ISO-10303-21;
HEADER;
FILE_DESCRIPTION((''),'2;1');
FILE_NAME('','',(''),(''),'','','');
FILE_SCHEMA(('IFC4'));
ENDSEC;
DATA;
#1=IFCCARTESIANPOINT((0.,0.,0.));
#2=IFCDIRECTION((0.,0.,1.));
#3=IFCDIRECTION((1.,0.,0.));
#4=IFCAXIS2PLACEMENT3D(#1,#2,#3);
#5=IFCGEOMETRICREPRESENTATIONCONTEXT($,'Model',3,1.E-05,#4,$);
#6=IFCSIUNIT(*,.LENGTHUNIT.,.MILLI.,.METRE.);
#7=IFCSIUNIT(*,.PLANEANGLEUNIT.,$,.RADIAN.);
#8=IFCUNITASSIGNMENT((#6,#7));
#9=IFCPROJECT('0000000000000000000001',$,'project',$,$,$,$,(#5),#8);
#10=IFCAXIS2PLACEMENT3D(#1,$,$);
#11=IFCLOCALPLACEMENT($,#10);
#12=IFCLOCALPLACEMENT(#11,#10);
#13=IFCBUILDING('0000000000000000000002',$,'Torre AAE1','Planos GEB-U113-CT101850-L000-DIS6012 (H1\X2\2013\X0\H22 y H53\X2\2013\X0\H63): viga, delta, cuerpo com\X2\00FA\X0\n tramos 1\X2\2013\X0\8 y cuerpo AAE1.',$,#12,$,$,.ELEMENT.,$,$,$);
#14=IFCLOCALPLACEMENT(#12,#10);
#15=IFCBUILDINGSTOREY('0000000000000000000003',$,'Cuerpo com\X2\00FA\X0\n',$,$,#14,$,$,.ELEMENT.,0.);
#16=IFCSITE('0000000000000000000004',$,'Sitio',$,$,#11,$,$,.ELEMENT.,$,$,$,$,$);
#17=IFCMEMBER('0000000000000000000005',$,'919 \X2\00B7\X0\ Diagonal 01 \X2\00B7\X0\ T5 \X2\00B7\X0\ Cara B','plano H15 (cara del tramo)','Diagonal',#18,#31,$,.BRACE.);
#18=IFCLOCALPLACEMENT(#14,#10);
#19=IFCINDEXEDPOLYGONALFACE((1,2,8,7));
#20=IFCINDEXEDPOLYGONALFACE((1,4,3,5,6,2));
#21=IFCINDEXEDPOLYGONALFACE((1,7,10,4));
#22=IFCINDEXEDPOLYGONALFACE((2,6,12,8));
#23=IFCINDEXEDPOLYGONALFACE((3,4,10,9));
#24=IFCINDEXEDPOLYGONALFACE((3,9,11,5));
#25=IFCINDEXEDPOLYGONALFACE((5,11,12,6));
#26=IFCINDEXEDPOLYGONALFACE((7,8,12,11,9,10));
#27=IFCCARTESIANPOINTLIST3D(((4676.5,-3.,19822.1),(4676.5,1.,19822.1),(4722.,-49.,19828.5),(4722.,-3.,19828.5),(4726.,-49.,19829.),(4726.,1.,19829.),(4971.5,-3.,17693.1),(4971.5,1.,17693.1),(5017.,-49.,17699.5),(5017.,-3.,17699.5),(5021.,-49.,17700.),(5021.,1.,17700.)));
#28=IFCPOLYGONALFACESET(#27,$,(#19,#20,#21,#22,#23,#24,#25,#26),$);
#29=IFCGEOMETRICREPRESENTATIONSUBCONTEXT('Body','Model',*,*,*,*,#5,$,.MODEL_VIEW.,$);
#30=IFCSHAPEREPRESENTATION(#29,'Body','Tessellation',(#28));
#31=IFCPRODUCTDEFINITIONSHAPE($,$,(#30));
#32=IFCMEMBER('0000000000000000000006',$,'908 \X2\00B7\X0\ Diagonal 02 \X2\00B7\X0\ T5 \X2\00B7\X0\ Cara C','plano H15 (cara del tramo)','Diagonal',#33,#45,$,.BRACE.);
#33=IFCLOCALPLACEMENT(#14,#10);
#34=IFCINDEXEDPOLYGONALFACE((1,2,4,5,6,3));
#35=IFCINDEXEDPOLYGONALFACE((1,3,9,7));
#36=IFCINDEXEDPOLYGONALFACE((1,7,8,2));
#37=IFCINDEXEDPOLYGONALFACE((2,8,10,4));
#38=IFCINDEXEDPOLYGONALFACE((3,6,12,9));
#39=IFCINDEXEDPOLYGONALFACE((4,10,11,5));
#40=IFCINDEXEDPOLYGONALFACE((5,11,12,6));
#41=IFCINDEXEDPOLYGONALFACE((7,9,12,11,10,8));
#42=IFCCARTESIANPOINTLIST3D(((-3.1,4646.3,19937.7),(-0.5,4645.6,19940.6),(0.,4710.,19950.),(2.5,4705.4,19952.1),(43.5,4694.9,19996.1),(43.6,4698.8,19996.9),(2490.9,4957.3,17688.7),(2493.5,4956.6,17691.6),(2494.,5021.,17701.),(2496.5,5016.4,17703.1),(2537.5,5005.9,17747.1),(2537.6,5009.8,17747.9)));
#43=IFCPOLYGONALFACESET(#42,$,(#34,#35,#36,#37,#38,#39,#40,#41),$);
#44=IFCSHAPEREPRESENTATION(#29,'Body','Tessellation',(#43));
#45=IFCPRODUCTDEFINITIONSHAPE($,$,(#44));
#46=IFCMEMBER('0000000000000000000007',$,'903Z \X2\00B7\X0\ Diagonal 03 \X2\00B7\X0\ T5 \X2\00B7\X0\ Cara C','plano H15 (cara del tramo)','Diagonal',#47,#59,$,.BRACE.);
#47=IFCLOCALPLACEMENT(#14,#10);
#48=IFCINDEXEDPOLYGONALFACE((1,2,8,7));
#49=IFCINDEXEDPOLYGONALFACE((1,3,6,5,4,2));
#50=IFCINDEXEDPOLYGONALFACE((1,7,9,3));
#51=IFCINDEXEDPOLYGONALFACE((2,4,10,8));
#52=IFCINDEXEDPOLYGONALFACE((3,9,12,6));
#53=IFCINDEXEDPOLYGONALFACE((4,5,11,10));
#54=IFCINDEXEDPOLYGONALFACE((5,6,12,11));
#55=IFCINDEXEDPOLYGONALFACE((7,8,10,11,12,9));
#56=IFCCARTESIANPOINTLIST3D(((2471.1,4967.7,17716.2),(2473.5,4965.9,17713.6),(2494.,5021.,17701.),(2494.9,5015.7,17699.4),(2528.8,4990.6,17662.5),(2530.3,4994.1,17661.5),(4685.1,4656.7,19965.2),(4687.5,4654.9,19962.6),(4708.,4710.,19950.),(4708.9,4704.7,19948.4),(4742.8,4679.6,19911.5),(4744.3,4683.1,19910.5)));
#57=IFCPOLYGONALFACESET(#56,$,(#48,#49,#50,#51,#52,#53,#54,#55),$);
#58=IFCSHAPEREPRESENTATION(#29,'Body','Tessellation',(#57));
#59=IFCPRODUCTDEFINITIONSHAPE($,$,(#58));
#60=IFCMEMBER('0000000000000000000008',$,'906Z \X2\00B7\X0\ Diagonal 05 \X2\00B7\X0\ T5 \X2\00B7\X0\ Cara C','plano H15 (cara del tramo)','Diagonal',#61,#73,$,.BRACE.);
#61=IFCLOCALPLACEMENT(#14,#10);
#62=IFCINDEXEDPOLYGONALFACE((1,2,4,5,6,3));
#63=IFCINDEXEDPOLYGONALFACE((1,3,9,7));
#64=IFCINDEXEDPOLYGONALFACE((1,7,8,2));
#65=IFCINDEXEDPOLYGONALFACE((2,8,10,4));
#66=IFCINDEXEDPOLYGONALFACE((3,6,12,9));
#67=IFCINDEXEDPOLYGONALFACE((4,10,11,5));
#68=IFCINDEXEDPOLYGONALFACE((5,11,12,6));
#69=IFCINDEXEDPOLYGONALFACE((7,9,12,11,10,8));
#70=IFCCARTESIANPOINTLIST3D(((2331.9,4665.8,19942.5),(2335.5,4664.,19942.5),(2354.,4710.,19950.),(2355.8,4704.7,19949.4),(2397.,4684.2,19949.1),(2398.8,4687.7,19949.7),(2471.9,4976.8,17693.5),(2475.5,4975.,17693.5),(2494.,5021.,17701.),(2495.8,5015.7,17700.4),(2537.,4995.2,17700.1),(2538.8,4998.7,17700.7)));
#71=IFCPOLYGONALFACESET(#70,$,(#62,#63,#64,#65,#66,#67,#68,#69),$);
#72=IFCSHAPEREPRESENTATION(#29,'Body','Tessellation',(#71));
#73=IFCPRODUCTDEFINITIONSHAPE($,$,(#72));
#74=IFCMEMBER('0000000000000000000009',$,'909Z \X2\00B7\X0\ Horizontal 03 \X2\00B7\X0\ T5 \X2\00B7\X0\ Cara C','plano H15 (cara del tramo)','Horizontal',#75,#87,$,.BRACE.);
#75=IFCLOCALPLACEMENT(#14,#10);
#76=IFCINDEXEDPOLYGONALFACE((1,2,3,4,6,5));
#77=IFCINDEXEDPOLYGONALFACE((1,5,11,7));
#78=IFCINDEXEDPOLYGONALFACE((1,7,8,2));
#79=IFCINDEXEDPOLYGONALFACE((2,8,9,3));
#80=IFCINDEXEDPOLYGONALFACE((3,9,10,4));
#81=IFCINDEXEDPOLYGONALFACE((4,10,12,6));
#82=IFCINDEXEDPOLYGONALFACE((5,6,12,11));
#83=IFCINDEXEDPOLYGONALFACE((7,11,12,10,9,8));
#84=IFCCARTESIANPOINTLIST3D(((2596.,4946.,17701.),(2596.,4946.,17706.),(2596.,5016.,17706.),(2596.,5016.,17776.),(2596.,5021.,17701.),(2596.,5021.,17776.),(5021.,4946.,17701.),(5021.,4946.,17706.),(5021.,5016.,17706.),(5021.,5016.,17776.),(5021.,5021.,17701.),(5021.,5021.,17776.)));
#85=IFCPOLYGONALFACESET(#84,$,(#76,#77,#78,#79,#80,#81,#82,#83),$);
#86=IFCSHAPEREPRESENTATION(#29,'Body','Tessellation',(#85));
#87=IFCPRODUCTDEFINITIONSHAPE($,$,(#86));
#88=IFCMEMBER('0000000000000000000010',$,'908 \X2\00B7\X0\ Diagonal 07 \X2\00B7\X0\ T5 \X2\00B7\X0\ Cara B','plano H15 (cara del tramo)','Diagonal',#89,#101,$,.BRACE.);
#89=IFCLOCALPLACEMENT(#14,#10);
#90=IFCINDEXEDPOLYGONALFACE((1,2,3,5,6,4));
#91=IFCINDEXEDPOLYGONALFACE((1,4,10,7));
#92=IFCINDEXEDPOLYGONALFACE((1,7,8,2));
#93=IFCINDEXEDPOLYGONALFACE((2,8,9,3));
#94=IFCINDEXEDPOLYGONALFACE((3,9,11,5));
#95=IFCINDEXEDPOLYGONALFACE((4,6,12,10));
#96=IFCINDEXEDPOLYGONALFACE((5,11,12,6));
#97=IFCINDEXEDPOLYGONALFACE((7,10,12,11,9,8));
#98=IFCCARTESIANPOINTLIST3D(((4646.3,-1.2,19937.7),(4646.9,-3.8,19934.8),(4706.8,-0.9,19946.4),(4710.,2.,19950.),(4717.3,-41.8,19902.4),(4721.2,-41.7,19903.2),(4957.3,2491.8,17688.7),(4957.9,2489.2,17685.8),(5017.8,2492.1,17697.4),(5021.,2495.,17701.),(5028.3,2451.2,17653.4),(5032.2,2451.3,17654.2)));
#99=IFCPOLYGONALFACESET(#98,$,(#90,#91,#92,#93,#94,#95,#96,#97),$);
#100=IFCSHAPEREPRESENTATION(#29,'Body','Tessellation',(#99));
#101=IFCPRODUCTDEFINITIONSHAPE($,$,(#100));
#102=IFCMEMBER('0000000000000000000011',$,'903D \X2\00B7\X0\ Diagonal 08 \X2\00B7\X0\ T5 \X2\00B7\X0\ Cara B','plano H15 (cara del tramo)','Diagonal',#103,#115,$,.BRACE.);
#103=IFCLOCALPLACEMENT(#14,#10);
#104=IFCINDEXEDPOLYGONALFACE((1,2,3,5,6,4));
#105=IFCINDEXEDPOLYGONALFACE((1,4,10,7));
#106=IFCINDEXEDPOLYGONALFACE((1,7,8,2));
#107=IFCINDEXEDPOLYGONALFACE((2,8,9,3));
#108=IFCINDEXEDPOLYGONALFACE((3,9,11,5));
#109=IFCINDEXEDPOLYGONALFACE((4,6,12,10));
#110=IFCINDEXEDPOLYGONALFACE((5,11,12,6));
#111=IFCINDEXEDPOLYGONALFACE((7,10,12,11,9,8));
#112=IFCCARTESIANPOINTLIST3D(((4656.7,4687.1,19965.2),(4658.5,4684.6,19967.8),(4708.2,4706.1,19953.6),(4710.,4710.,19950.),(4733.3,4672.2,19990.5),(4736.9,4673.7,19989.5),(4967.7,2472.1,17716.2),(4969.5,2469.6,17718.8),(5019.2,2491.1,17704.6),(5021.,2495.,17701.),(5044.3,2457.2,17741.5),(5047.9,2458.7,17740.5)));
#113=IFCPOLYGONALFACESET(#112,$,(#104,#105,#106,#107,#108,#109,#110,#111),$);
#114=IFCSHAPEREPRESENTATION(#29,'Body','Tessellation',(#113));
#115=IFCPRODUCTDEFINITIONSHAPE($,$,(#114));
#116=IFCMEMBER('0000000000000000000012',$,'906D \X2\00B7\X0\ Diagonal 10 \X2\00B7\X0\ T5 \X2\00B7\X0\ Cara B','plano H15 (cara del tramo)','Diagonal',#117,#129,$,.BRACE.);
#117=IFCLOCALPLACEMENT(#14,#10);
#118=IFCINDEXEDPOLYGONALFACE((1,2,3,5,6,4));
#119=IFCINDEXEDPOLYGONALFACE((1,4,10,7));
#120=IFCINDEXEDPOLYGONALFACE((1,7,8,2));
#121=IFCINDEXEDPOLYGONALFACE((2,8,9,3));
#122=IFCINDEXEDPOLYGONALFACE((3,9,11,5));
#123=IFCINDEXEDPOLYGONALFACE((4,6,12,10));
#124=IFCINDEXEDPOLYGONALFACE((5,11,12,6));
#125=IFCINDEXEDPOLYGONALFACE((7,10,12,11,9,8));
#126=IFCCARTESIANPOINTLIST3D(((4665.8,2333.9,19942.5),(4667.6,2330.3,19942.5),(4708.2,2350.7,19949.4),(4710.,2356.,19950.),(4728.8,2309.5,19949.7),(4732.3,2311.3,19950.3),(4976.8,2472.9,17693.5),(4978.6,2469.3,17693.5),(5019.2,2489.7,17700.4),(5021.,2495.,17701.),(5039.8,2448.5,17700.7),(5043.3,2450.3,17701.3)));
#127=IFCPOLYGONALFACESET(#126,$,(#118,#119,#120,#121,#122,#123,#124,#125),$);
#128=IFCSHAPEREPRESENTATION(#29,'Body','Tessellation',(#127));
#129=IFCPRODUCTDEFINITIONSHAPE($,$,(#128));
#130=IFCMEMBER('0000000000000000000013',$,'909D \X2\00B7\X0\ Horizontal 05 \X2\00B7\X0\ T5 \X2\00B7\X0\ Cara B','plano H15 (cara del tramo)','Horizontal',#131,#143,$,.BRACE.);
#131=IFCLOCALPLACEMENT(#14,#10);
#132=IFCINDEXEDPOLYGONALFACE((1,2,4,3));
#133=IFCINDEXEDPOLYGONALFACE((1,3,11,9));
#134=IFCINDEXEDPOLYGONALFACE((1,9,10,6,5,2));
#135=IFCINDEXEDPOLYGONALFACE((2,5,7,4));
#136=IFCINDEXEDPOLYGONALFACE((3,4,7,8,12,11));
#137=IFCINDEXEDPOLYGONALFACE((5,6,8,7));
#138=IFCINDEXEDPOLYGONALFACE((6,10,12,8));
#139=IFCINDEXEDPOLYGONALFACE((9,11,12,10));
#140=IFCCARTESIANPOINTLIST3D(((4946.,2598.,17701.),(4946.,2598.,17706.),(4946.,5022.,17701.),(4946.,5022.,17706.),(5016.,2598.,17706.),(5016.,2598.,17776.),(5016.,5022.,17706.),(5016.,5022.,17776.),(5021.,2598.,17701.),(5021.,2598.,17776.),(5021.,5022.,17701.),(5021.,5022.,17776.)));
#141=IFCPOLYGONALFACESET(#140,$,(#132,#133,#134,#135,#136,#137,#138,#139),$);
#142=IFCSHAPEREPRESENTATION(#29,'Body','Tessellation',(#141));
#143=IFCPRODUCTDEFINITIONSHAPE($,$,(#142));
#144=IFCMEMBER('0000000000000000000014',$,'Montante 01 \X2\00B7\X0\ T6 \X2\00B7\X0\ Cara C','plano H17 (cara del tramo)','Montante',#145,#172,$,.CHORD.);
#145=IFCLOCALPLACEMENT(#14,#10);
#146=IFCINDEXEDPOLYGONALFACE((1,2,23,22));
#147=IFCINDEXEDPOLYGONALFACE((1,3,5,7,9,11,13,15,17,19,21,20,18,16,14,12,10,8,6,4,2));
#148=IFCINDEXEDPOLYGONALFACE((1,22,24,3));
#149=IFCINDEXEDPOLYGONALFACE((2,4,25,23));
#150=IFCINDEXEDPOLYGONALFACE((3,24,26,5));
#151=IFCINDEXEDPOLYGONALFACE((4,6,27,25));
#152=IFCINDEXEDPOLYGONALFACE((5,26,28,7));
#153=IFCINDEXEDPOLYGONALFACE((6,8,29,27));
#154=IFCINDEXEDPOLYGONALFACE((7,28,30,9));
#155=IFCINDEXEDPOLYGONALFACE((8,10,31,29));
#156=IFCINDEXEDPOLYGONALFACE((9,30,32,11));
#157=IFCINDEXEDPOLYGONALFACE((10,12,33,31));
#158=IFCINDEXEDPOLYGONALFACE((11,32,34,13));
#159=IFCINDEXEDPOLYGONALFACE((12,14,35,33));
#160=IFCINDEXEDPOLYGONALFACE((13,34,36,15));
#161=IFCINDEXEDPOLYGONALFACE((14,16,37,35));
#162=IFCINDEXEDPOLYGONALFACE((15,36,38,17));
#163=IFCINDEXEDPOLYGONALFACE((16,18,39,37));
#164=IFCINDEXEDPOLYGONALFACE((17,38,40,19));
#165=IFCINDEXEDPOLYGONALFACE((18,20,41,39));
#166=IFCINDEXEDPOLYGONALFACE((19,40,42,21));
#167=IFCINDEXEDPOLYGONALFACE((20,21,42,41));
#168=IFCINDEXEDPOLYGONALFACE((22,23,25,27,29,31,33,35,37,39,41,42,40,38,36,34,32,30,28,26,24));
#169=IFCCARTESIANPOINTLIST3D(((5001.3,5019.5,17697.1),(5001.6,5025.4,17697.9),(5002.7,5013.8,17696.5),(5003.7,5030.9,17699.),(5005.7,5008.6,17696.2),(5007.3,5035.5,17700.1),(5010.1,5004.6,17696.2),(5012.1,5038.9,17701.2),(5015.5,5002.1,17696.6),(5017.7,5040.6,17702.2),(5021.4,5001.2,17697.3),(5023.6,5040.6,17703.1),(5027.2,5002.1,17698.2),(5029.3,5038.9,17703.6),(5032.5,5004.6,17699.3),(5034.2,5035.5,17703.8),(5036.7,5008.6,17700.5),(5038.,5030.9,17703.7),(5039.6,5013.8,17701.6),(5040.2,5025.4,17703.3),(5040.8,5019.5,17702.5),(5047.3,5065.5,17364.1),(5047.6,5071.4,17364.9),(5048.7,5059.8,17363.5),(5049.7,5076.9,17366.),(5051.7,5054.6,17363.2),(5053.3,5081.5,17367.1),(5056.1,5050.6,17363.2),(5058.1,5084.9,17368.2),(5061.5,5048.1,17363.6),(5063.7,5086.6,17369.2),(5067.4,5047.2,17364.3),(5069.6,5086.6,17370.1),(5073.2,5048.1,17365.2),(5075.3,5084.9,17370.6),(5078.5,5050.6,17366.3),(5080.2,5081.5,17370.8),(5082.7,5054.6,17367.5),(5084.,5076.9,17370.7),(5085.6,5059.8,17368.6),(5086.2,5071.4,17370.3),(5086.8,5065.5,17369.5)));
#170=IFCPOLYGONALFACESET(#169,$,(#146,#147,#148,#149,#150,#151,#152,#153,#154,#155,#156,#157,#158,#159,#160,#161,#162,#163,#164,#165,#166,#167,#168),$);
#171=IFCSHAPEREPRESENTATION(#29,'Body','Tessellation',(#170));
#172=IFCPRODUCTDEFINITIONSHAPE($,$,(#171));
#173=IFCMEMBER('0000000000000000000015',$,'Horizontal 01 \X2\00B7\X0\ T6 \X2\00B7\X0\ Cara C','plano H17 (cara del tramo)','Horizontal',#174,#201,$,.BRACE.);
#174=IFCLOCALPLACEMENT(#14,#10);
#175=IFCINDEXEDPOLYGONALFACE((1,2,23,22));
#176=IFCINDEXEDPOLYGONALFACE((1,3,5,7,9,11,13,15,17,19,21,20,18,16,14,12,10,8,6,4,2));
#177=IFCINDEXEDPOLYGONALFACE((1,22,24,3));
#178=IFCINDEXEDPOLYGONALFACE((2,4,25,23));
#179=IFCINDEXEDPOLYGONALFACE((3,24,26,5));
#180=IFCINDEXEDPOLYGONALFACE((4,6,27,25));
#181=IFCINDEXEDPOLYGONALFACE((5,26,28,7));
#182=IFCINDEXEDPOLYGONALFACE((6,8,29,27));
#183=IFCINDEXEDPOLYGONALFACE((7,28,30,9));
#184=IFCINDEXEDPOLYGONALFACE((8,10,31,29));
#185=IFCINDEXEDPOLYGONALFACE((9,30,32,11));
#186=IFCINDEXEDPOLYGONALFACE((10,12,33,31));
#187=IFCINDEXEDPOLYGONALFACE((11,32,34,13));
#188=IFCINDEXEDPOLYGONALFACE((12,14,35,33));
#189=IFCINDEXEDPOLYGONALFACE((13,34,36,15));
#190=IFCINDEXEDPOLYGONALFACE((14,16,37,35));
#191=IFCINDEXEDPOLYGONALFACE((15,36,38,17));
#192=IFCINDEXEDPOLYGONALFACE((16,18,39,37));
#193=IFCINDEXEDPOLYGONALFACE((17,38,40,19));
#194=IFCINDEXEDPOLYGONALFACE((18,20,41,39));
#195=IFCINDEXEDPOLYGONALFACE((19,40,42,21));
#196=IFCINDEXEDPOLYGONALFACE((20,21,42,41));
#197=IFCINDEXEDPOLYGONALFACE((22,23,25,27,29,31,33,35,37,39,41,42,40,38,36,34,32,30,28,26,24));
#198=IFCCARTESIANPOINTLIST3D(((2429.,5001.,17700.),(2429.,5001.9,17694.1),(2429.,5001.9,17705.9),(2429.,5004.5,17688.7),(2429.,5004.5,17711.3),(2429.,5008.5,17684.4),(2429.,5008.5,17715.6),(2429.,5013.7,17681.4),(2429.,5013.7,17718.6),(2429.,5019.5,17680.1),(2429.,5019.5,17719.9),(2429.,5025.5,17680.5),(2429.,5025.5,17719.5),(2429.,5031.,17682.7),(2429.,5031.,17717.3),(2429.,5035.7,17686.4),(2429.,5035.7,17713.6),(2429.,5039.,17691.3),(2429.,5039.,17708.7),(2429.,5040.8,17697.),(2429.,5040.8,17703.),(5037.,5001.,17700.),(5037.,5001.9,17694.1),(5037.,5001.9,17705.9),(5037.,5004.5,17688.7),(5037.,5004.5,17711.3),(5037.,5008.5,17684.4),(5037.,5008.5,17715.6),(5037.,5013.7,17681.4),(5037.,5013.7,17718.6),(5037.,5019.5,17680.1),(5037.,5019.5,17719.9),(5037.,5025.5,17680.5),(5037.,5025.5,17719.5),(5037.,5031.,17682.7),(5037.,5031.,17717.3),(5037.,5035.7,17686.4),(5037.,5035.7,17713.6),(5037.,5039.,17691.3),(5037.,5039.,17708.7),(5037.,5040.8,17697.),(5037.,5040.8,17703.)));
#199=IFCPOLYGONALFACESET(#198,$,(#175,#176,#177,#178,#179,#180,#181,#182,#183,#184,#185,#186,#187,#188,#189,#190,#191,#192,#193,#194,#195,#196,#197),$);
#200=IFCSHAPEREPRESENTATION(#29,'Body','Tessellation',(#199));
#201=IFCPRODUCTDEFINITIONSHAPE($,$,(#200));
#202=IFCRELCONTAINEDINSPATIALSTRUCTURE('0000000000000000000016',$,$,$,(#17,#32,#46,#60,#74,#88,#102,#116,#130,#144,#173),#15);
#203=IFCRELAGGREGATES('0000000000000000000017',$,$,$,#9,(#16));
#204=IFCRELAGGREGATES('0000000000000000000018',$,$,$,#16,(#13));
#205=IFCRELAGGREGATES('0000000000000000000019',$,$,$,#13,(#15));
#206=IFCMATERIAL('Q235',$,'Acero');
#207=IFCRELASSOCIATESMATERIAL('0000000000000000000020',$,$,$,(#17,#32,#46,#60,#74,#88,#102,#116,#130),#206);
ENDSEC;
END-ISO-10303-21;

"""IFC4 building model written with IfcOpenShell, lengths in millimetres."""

from ifc_helpers import new_model, si_unit, frame, frame_2d, origin, origin_with_axes, place, context, subcontext, project, spatial, circle, l_section, extrude, material, element, save


model = new_model("IFC4")

# Units and contexts
model_context = context("Model", 3, precision=1e-05, world=origin_with_axes())
body_context = subcontext(model_context, "Body", "Model", "MODEL_VIEW")
ifc_project = project(units=[si_unit("LENGTHUNIT", "METRE", prefix="MILLI"), si_unit("PLANEANGLEUNIT", "RADIAN")], contexts=[model_context])

# Site, building, storey
site_placement = place(None, origin())
site = spatial("IfcSite", under=ifc_project, at=site_placement, Name="Sitio", CompositionType="ELEMENT")
building_placement = place(site_placement, origin())
building = spatial("IfcBuilding", under=site, at=building_placement, Name="Torre AAE1", Description="Planos GEB-U113-CT101850-L000-DIS6012 (H1–H22 y H53–H63): viga, delta, cuerpo común tramos 1–8 y cuerpo AAE1.", CompositionType="ELEMENT")
storey_placement = place(building_placement, origin())
storey = spatial("IfcBuildingStorey", under=building, at=storey_placement, Name="Cuerpo común", CompositionType="ELEMENT", Elevation=0.0)

# Members
ifc_material_1 = material(Name="Q235", Category="Acero")
member_1_placement = place(storey_placement, frame((5021.0, 1.0, 17700.0), z_axis=(-0.137251, 0.0, 0.990536), x_axis=(-0.990536, -0.000207, -0.137251)))
element("IfcMember", 1, at=member_1_placement, inside=storey, material=ifc_material_1, Name="919 · Diagonal 01 · T5 · Cara B", Description="plano H15 (cara del tramo)", ObjectType="Diagonal", PredefinedType="BRACE", context=body_context, shape_type="SweptSolid", body=[
    extrude(l_section(Depth=50.0, Width=50.0, Thickness=4.0, at=frame_2d((25.0, 25.0))), None, (0.0, 0.0, 1.0), 2149.3),
])
member_2_placement = place(storey_placement, frame((2494.0, 5021.0, 17701.0), z_axis=(-0.739478, -0.092212, 0.666835), x_axis=(-0.048288, -0.980756, -0.189171)))
element("IfcMember", 2, at=member_2_placement, inside=storey, material=ifc_material_1, Name="908 · Diagonal 02 · T5 · Cara C", Description="plano H15 (cara del tramo)", ObjectType="Diagonal", PredefinedType="BRACE", context=body_context, shape_type="SweptSolid", body=[
    extrude(l_section(Depth=65.0, Width=65.0, Thickness=4.0, at=frame_2d((32.5, 32.5))), None, (0.0, 0.0, 1.0), 3372.6),
])
member_3_placement = place(storey_placement, frame((2494.0, 5021.0, 17701.0), z_axis=(0.698158, -0.09807, 0.709195), x_axis=(-0.382258, -0.888624, 0.253427)))
element("IfcMember", 3, at=member_3_placement, inside=storey, material=ifc_material_1, Name="903Z · Diagonal 03 · T5 · Cara C", Description="plano H15 (cara del tramo)", ObjectType="Diagonal", PredefinedType="BRACE", context=body_context, shape_type="SweptSolid", body=[
    extrude(l_section(Depth=60.0, Width=60.0, Thickness=4.0, at=frame_2d((30.0, 30.0))), None, (0.0, 0.0, 1.0), 3171.2),
])
member_4_placement = place(storey_placement, frame((2494.0, 5021.0, 17701.0), z_axis=(-0.061546, -0.136721, 0.988696), x_axis=(-0.44169, -0.884571, -0.149817)))
element("IfcMember", 4, at=member_4_placement, inside=storey, material=ifc_material_1, Name="906Z · Diagonal 05 · T5 · Cara C", Description="plano H15 (cara del tramo)", ObjectType="Diagonal", PredefinedType="BRACE", context=body_context, shape_type="SweptSolid", body=[
    extrude(l_section(Depth=50.0, Width=50.0, Thickness=4.0, at=frame_2d((25.0, 25.0))), None, (0.0, 0.0, 1.0), 2274.7),
])
member_5_placement = place(storey_placement, frame((5021.0, 5021.0, 17701.0), z_axis=(-1.0, 0.0, 0.0), x_axis=(0.0, -1.0, 0.0)))
element("IfcMember", 5, at=member_5_placement, inside=storey, material=ifc_material_1, Name="909Z · Horizontal 03 · T5 · Cara C", Description="plano H15 (cara del tramo)", ObjectType="Horizontal", PredefinedType="BRACE", context=body_context, shape_type="SweptSolid", body=[
    extrude(l_section(Depth=75.0, Width=75.0, Thickness=5.0, at=frame_2d((37.5, 37.5))), None, (0.0, 0.0, 1.0), 2425.0),
])
member_6_placement = place(storey_placement, frame((5021.0, 2495.0, 17701.0), z_axis=(-0.092233, -0.739344, 0.666981), x_axis=(-0.980712, -0.048477, -0.189352)))
element("IfcMember", 6, at=member_6_placement, inside=storey, material=ifc_material_1, Name="908 · Diagonal 07 · T5 · Cara B", Description="plano H15 (cara del tramo)", ObjectType="Diagonal", PredefinedType="BRACE", context=body_context, shape_type="SweptSolid", body=[
    extrude(l_section(Depth=65.0, Width=65.0, Thickness=4.0, at=frame_2d((32.5, 32.5))), None, (0.0, 0.0, 1.0), 3371.9),
])
member_7_placement = place(storey_placement, frame((5021.0, 2495.0, 17701.0), z_axis=(-0.098049, 0.69832, 0.709039), x_axis=(-0.888595, -0.382229, 0.253573)))
element("IfcMember", 7, at=member_7_placement, inside=storey, material=ifc_material_1, Name="903D · Diagonal 08 · T5 · Cara B", Description="plano H15 (cara del tramo)", ObjectType="Diagonal", PredefinedType="BRACE", context=body_context, shape_type="SweptSolid", body=[
    extrude(l_section(Depth=60.0, Width=60.0, Thickness=4.0, at=frame_2d((30.0, 30.0))), None, (0.0, 0.0, 1.0), 3171.9),
])
member_8_placement = place(storey_placement, frame((5021.0, 2495.0, 17701.0), z_axis=(-0.136724, -0.061108, 0.988723), x_axis=(-0.884459, -0.441979, -0.149623)))
element("IfcMember", 8, at=member_8_placement, inside=storey, material=ifc_material_1, Name="906D · Diagonal 10 · T5 · Cara B", Description="plano H15 (cara del tramo)", ObjectType="Diagonal", PredefinedType="BRACE", context=body_context, shape_type="SweptSolid", body=[
    extrude(l_section(Depth=50.0, Width=50.0, Thickness=4.0, at=frame_2d((25.0, 25.0))), None, (0.0, 0.0, 1.0), 2274.7),
])
member_9_placement = place(storey_placement, frame((5021.0, 2598.0, 17701.0), z_axis=(0.0, 1.0, 0.0), x_axis=(-1.0, 0.0, 0.0)))
element("IfcMember", 9, at=member_9_placement, inside=storey, material=ifc_material_1, Name="909D · Horizontal 05 · T5 · Cara B", Description="plano H15 (cara del tramo)", ObjectType="Horizontal", PredefinedType="BRACE", context=body_context, shape_type="SweptSolid", body=[
    extrude(l_section(Depth=75.0, Width=75.0, Thickness=5.0, at=frame_2d((37.5, 37.5))), None, (0.0, 0.0, 1.0), 2424.0),
])
member_10_placement = place(storey_placement, frame((5021.0, 5021.0, 17700.0), z_axis=(0.135575, 0.135575, -0.981447), x_axis=(0.018552, -0.990767, -0.1343)))
element("IfcMember", 10, at=member_10_placement, inside=storey, Name="Montante 01 · T6 · Cara C", Description="plano H17 (cara del tramo)", ObjectType="Montante", PredefinedType="CHORD", context=body_context, shape_type="SweptSolid", body=[
    extrude(circle(Radius=20.0), None, (0.0, 0.0, 1.0), 339.3),
])
for number, where, z_axis, x_axis, name in (
    (11, (5037.0, 5021.0, 17700.0), (-1.0, 0.0, 0.0), (0.0, -1.0, 0.0), "Horizontal 01 · T6 · Cara C"),
):
    element("IfcMember", number, at=place(storey_placement, frame(where, z_axis=z_axis, x_axis=x_axis)), inside=storey, Name=name, Description="plano H17 (cara del tramo)", ObjectType="Horizontal", PredefinedType="BRACE", context=body_context, shape_type="SweptSolid", body=[
        extrude(circle(Radius=20.0), None, (0.0, 0.0, 1.0), 2608.0),
    ])

save(model, "model.ifc")
